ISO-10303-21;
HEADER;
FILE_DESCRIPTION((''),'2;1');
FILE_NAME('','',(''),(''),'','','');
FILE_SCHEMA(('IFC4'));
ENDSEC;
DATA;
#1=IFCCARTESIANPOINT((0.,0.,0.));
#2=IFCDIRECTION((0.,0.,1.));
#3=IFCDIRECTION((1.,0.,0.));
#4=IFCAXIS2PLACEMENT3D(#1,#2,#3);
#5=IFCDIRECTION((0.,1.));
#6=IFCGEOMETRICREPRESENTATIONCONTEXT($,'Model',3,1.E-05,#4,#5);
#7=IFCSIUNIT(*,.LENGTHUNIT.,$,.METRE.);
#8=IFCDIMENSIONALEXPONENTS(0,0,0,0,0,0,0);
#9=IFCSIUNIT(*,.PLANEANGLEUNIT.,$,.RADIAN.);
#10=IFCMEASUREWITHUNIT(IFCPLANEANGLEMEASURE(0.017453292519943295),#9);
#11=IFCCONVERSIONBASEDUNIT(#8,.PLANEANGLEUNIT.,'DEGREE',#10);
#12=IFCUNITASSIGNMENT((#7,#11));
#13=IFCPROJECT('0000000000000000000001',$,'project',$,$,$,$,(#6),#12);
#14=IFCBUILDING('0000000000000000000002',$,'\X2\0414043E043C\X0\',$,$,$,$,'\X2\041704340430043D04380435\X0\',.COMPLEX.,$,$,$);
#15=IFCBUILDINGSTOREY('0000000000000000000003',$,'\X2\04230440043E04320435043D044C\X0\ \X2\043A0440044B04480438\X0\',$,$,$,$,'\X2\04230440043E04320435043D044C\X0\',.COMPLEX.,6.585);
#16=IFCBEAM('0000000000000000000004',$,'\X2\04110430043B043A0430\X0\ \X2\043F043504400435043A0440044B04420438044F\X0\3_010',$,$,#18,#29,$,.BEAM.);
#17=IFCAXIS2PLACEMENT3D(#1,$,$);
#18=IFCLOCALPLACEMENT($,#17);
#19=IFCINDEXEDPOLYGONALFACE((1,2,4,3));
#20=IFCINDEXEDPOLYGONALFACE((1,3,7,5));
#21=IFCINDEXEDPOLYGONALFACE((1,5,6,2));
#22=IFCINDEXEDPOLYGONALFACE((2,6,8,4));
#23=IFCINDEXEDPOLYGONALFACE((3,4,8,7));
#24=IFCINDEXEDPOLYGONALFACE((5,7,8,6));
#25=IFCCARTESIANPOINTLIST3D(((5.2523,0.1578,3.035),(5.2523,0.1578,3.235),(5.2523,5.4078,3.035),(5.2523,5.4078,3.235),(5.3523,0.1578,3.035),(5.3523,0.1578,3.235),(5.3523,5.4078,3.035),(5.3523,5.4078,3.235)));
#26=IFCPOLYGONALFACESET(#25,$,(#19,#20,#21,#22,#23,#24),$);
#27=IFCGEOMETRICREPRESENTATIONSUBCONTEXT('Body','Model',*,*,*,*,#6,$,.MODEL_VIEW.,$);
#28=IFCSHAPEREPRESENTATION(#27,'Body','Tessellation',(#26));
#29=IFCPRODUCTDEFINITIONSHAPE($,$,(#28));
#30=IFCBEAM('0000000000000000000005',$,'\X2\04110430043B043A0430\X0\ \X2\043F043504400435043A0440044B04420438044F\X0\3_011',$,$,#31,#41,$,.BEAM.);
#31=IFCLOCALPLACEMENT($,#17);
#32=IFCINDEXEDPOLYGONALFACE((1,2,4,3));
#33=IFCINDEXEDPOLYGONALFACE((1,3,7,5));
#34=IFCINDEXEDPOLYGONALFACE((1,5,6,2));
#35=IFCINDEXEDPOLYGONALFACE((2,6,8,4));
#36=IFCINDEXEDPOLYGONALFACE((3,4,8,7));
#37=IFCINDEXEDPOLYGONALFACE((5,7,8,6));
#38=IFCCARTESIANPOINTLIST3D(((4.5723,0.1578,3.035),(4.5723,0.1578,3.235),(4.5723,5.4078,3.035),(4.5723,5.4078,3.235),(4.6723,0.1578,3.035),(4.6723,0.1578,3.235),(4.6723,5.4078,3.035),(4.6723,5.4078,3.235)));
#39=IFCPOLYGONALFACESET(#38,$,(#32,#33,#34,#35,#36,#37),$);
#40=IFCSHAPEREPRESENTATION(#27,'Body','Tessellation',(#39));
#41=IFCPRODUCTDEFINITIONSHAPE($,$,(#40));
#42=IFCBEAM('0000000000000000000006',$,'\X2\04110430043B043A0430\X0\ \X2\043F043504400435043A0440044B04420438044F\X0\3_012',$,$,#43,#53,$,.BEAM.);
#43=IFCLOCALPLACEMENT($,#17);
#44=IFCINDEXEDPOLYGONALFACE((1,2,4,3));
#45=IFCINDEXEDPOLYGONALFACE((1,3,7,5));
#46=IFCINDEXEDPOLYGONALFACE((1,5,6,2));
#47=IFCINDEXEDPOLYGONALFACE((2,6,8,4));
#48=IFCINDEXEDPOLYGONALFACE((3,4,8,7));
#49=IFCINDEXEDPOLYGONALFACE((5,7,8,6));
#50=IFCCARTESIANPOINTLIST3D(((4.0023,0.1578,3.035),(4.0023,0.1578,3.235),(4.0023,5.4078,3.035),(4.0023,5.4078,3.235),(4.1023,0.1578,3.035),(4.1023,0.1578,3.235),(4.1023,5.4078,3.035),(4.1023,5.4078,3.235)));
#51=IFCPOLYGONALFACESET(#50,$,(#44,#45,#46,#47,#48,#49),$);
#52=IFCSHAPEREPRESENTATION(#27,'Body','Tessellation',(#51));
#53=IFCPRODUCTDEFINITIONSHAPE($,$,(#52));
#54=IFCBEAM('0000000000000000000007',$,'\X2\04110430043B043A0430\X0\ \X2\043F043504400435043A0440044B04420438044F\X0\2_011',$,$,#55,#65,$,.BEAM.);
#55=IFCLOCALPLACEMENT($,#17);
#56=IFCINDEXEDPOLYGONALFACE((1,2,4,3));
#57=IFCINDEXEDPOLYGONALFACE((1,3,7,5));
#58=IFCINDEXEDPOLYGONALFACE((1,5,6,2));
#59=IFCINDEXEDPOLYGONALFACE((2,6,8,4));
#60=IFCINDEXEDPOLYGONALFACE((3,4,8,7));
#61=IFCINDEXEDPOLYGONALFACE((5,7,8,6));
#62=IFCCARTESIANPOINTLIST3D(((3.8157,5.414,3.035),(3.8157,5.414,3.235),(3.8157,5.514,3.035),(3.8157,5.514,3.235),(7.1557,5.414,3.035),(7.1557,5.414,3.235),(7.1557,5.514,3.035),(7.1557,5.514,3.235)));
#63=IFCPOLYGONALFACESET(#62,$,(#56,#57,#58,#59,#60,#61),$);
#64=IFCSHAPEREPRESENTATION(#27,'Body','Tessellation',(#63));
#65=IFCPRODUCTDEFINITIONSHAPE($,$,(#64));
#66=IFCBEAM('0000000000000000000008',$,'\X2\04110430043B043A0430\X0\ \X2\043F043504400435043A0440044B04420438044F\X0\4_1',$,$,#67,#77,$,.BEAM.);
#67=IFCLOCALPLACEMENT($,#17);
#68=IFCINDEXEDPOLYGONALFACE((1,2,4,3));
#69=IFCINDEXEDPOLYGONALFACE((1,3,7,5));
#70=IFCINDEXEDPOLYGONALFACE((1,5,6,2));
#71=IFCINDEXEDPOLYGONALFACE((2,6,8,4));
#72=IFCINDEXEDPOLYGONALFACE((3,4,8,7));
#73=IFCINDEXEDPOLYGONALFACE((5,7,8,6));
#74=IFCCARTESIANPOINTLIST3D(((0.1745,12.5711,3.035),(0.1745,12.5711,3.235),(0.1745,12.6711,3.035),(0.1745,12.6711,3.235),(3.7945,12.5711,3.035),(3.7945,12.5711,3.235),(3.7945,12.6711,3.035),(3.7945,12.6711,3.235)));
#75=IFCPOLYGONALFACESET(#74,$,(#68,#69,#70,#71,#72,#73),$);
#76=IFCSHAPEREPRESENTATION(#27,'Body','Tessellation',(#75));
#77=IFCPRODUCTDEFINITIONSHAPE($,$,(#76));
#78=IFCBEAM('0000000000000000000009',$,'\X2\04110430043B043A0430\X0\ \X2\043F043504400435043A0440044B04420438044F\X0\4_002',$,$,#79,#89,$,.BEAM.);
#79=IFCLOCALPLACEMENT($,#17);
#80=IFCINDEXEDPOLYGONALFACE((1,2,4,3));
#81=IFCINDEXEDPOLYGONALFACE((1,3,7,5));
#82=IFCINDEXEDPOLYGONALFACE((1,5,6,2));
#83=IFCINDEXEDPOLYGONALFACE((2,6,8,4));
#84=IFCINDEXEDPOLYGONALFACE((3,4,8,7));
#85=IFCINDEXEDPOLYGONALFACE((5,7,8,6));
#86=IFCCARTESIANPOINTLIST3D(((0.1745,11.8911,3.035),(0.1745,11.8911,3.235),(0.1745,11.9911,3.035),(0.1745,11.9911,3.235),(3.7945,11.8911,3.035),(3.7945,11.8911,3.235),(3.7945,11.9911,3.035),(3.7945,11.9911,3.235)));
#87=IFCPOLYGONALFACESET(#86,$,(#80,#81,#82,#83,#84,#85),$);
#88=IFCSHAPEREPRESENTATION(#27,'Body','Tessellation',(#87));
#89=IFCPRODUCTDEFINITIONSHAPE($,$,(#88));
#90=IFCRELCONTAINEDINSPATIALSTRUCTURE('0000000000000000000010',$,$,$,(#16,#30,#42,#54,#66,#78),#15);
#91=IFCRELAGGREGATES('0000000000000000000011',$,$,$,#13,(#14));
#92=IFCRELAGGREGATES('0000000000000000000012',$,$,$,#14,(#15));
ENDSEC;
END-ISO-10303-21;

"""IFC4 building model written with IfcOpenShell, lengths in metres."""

from ifc_helpers import new_model, entity, si_unit, converted_unit, direction, frame, frame_2d, origin_with_axes, origin_2d_with_axis, place, context, subcontext, project, spatial, rectangle, extrude, element, save


model = new_model("IFC4")

# Units and contexts
model_context = context("Model", 3, precision=1e-05, world=origin_with_axes(), true_north=direction((0.0, 1.0)))
body_context = subcontext(model_context, "Body", "Model", "MODEL_VIEW")
ifc_project = project(units=[si_unit("LENGTHUNIT", "METRE"), converted_unit("PLANEANGLEUNIT", "DEGREE", entity("IfcPlaneAngleMeasure", 0.017453292519943295), si_unit("PLANEANGLEUNIT", "RADIAN"), dimensions=[0, 0, 0, 0, 0, 0, 0])], contexts=[model_context])

# Building, storey
building = spatial("IfcBuilding", under=ifc_project, Name="Дом", LongName="Здание", CompositionType="COMPLEX")
storey = spatial("IfcBuildingStorey", under=building, Name="Уровень крыши", LongName="Уровень", CompositionType="COMPLEX", Elevation=6.585)

# Beams
placement = place(None, origin_with_axes())
element("IfcBeam", 1, at=placement, inside=storey, Name="Балка перекрытия3_010", PredefinedType="BEAM", context=body_context, shape_type="SweptSolid", body=[
    extrude(rectangle(XDim=0.1, YDim=5.25, at=origin_2d_with_axis()), frame((5.3023, 2.7828, 3.035), z_axis=(0.0, 0.0, 1.0), x_axis=(1.0, 0.0, 0.0)), (0.0, 0.0, 1.0), 0.2),
])
element("IfcBeam", 2, at=placement, inside=storey, Name="Балка перекрытия3_011", PredefinedType="BEAM", context=body_context, shape_type="SweptSolid", body=[
    extrude(rectangle(XDim=0.1, YDim=5.25, at=origin_2d_with_axis()), frame((4.6223, 2.7828, 3.035), z_axis=(0.0, 0.0, 1.0), x_axis=(1.0, 0.0, 0.0)), (0.0, 0.0, 1.0), 0.2),
])
element("IfcBeam", 3, at=placement, inside=storey, Name="Балка перекрытия3_012", PredefinedType="BEAM", context=body_context, shape_type="SweptSolid", body=[
    extrude(rectangle(XDim=0.1, YDim=5.25, at=origin_2d_with_axis()), frame((4.0523, 2.7828, 3.035), z_axis=(0.0, 0.0, 1.0), x_axis=(1.0, 0.0, 0.0)), (0.0, 0.0, 1.0), 0.2),
])
element("IfcBeam", 4, at=placement, inside=storey, Name="Балка перекрытия2_011", PredefinedType="BEAM", context=body_context, shape_type="SweptSolid", body=[
    extrude(rectangle(XDim=3.34, YDim=0.1, at=frame_2d((0.0, 0.0), x_axis=(1.0, 0.0))), frame((5.4857, 5.464, 3.035), z_axis=(0.0, 0.0, 1.0), x_axis=(1.0, 0.0, 0.0)), (0.0, 0.0, 1.0), 0.2),
])
element("IfcBeam", 5, at=placement, inside=storey, Name="Балка перекрытия4_1", PredefinedType="BEAM", context=body_context, shape_type="SweptSolid", body=[
    extrude(rectangle(XDim=3.62, YDim=0.1, at=origin_2d_with_axis()), frame((1.9845, 12.6211, 3.035), z_axis=(0.0, 0.0, 1.0), x_axis=(1.0, 0.0, 0.0)), (0.0, 0.0, 1.0), 0.2),
])
element("IfcBeam", 6, at=placement, inside=storey, Name="Балка перекрытия4_002", PredefinedType="BEAM", context=body_context, shape_type="SweptSolid", body=[
    extrude(rectangle(XDim=3.62, YDim=0.1, at=origin_2d_with_axis()), frame((1.9845, 11.9411, 3.035), z_axis=(0.0, 0.0, 1.0), x_axis=(1.0, 0.0, 0.0)), (0.0, 0.0, 1.0), 0.2),
])

save(model, "model.ifc")
